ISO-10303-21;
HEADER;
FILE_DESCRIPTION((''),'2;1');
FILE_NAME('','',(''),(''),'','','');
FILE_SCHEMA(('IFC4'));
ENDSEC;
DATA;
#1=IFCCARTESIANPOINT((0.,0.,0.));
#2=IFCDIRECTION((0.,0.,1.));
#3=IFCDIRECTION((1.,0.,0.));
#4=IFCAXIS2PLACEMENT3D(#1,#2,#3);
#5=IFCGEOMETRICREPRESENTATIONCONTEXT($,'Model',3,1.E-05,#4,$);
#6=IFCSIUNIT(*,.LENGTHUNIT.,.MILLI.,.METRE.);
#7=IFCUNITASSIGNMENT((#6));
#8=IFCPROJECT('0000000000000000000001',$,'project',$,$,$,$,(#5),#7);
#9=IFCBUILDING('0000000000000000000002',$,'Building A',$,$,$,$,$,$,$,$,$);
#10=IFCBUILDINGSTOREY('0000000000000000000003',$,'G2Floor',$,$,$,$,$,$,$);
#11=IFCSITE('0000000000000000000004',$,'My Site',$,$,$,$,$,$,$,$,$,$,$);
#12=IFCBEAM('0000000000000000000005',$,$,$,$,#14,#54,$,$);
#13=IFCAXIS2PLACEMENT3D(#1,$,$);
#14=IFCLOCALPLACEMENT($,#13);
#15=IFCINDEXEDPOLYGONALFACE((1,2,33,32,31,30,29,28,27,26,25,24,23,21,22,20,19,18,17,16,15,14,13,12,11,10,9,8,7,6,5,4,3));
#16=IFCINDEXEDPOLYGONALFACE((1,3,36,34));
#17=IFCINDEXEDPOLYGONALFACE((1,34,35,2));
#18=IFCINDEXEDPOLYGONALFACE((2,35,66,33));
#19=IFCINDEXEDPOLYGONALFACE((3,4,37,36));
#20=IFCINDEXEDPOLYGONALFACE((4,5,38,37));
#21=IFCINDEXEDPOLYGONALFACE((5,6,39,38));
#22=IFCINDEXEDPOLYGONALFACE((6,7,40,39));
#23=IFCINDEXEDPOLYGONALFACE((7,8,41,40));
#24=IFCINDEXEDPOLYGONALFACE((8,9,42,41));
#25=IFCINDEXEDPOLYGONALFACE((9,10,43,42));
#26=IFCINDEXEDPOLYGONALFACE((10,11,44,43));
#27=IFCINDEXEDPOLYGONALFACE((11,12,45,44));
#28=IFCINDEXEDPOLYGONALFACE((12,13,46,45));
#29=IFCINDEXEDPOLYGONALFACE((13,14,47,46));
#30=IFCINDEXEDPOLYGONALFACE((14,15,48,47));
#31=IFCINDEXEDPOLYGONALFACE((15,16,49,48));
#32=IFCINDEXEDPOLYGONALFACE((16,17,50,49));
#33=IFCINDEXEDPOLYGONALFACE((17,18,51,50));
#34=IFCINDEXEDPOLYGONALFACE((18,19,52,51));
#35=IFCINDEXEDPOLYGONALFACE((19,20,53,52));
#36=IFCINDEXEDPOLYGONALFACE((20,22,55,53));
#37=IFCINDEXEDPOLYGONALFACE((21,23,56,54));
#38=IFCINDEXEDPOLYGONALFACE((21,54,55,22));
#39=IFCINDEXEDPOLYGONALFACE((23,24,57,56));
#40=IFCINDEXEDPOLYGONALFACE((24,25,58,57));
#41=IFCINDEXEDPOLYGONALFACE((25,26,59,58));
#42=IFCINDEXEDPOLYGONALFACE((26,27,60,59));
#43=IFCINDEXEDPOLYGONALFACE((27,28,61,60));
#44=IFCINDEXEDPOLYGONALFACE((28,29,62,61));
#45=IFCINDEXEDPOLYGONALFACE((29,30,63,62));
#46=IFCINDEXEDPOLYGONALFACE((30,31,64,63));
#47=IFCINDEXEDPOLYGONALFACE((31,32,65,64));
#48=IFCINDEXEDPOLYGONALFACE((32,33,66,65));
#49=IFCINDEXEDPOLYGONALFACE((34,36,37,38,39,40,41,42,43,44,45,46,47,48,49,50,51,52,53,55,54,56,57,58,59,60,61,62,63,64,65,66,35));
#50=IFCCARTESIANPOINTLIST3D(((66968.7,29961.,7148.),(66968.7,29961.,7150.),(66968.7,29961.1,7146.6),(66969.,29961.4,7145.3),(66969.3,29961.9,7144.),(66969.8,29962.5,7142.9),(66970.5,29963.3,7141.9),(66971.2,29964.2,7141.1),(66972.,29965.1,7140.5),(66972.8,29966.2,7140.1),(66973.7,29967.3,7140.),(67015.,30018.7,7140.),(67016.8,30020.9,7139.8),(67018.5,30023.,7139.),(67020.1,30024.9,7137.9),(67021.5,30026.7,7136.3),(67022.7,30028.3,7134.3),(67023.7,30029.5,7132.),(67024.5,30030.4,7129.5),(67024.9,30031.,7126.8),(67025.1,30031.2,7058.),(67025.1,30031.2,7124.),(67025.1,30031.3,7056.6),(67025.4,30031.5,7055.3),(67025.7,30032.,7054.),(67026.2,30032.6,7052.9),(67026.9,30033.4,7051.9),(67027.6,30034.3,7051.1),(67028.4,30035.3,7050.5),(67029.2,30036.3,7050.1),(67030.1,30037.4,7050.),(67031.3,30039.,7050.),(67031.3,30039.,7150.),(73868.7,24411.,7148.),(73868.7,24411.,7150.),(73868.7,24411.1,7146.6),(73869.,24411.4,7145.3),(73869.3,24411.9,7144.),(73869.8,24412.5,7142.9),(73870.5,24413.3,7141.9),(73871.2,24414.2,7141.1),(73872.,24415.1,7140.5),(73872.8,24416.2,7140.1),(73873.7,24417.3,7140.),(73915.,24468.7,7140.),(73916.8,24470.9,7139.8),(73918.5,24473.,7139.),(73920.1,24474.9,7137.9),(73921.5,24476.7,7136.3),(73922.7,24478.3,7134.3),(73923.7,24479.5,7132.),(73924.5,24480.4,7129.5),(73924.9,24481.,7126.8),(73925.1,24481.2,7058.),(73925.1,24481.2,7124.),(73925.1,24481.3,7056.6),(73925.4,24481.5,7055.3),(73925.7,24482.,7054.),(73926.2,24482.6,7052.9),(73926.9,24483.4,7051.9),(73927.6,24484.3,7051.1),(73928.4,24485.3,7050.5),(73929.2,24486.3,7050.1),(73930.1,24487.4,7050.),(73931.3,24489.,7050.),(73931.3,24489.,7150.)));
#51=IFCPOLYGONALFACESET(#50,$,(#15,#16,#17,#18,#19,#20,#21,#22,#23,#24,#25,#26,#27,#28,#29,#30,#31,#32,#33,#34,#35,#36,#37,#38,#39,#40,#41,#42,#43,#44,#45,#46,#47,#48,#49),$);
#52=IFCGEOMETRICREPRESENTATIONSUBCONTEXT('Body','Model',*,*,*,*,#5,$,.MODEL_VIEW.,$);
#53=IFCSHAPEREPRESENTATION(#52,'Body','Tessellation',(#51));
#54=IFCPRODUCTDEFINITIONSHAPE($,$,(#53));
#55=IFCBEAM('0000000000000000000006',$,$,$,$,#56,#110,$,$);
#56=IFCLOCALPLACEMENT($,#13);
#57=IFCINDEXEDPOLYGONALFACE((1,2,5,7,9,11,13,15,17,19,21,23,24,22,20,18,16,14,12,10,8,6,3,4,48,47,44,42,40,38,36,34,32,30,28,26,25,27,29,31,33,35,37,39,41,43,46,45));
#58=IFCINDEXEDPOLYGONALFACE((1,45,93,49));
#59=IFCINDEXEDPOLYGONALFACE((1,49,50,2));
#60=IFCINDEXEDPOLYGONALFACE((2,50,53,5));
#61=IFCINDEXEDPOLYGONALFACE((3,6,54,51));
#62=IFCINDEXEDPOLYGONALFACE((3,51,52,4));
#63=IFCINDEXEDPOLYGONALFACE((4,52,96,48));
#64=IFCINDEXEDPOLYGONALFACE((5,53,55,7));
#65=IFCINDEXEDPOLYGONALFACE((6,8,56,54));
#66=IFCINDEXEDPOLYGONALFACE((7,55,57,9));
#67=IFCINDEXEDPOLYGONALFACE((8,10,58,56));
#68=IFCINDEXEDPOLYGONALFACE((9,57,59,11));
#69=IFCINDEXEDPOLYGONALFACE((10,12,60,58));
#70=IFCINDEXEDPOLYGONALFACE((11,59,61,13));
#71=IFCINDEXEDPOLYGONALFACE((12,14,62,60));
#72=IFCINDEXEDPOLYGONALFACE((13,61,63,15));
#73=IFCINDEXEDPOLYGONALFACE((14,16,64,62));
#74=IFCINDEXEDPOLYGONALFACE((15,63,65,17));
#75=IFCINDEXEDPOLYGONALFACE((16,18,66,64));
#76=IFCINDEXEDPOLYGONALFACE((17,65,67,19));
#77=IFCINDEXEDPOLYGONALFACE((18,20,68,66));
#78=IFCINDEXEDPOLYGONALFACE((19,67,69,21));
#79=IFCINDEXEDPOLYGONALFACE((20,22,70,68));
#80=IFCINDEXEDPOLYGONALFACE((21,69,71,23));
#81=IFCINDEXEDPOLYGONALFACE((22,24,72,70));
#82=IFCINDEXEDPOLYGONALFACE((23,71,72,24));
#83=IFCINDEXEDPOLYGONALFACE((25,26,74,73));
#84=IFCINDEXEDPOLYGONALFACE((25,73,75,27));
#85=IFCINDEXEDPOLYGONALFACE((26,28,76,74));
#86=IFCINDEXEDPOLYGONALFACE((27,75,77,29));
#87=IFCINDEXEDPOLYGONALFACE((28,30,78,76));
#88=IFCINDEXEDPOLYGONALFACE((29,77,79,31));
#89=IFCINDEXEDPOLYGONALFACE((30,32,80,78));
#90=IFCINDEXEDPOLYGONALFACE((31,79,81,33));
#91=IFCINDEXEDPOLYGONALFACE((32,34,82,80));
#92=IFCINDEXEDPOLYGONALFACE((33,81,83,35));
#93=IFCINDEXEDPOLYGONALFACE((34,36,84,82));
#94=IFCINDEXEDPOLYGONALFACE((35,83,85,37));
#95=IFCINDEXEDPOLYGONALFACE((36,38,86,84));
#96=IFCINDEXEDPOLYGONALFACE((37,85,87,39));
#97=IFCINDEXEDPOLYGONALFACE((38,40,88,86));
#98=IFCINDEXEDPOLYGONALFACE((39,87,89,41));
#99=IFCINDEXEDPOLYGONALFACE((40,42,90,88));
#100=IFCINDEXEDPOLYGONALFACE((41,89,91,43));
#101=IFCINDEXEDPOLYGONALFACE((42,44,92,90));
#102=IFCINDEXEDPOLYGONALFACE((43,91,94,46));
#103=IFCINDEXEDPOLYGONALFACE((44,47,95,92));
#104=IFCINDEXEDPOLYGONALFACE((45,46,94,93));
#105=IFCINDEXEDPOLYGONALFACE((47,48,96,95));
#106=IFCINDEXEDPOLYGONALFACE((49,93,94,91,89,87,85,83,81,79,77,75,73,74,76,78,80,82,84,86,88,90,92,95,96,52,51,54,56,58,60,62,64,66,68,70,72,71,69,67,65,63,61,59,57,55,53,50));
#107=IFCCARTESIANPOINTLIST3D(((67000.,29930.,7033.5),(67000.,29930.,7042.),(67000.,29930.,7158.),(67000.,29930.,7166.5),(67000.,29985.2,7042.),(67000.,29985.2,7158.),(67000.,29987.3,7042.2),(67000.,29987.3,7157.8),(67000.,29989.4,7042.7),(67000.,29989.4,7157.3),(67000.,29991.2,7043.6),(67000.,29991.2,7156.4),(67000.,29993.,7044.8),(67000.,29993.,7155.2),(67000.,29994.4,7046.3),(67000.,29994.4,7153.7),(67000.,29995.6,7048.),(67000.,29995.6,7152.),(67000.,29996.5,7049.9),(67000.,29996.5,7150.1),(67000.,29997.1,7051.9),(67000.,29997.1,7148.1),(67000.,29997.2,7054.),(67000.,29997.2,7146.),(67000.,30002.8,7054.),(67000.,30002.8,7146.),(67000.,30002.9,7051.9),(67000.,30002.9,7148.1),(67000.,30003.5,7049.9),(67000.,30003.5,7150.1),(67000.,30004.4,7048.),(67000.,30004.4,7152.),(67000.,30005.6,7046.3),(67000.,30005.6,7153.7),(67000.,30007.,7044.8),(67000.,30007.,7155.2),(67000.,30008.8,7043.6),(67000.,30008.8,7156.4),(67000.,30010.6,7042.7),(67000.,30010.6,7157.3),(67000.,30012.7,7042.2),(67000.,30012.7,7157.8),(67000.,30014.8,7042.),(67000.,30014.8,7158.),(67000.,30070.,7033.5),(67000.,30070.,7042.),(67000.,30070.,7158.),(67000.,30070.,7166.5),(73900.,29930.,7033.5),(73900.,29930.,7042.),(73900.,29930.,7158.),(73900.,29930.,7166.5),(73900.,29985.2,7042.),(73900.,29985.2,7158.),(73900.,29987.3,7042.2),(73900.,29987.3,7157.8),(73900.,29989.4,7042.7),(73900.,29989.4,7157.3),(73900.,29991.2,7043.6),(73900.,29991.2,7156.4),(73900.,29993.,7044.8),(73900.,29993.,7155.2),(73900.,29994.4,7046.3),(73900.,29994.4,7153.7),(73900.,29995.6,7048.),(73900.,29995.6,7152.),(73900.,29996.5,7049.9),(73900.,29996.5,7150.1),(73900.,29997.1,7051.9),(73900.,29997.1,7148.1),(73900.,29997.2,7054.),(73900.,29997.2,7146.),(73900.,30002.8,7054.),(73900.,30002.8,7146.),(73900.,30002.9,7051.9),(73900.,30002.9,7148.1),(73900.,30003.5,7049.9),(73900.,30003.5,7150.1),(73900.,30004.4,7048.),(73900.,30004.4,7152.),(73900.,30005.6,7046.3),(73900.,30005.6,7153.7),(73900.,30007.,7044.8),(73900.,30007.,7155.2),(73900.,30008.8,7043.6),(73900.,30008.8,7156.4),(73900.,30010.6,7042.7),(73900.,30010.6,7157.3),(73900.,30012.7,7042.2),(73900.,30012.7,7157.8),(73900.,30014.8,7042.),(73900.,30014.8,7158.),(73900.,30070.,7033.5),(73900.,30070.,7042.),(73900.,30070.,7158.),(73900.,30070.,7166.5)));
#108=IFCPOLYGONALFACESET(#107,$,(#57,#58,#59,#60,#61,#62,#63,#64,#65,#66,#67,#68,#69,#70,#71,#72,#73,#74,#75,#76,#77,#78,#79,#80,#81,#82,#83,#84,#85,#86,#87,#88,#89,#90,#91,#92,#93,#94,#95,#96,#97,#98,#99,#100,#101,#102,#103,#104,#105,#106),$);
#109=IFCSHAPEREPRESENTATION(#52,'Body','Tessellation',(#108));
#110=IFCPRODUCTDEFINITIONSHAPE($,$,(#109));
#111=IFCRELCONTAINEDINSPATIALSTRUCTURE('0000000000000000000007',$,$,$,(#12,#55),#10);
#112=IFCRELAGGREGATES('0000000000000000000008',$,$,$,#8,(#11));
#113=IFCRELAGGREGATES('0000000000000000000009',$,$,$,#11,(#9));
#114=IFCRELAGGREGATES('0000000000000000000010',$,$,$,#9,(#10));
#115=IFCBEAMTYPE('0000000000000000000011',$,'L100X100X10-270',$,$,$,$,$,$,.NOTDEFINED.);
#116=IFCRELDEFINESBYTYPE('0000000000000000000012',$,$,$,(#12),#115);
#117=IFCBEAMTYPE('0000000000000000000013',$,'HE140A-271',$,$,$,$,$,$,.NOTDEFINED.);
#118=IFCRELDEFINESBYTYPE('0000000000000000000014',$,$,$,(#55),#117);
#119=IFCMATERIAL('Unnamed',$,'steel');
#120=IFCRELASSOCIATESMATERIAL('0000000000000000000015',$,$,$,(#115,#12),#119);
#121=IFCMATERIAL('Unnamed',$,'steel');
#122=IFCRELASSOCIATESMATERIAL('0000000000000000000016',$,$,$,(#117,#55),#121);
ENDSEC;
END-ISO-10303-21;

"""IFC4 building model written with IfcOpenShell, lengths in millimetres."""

from ifc_helpers import new_model, si_unit, frame, origin_with_axes, place, context, subcontext, project, spatial, polyline, outline, extrude, material, material_profile, profile_set, profile_usage, type_object, element, save


model = new_model("IFC4")

# Units and contexts
model_context = context("Model", 3, precision=1e-05, world=origin_with_axes())
body_context = subcontext(model_context, "Body", "Model", "MODEL_VIEW")
ifc_project = project(units=[si_unit("LENGTHUNIT", "METRE", prefix="MILLI")], contexts=[model_context])

# Site, building, storey
site = spatial("IfcSite", under=ifc_project, Name="My Site")
building = spatial("IfcBuilding", under=site, Name="Building A")
storey = spatial("IfcBuildingStorey", under=building, Name="G2Floor")

# Beams
ifc_material_1 = material(Name="Unnamed", Category="steel")
ifc_material_profile_1 = material_profile(ifc_material_1, outline(polyline([(-50.0, -50.0), (50.0, -50.0), (50.0, -50.0), (50.0, -48.0), (50.0, -48.0), (49.9, -46.6), (49.9, -46.6), (49.5, -45.3), (49.5, -45.3), (48.9, -44.0), (48.9, -44.0), (48.1, -42.9), (48.1, -42.9), (47.1, -41.9), (47.1, -41.9), (46.0, -41.1), (46.0, -41.1), (44.7, -40.5), (44.7, -40.5), (43.4, -40.1), (43.4, -40.1), (42.0, -40.0), (42.0, -40.0), (-24.0, -40.0), (-24.0, -40.0), (-26.8, -39.8), (-26.8, -39.8), (-29.5, -39.0), (-29.5, -39.0), (-32.0, -37.9), (-32.0, -37.9), (-34.3, -36.3), (-34.3, -36.3), (-36.3, -34.3), (-36.3, -34.3), (-37.9, -32.0), (-37.9, -32.0), (-39.0, -29.5), (-39.0, -29.5), (-39.8, -26.8), (-39.8, -26.8), (-40.0, -24.0), (-40.0, -24.0), (-40.0, 42.0), (-40.0, 42.0), (-40.1, 43.4), (-40.1, 43.4), (-40.5, 44.7), (-40.5, 44.7), (-41.1, 46.0), (-41.1, 46.0), (-41.9, 47.1), (-41.9, 47.1), (-42.9, 48.1), (-42.9, 48.1), (-44.0, 48.9), (-44.0, 48.9), (-45.3, 49.5), (-45.3, 49.5), (-46.6, 49.9), (-46.6, 49.9), (-48.0, 50.0), (-48.0, 50.0), (-50.0, 50.0), (-50.0, 50.0), (-50.0, -50.0)])))
ifc_profile_set_1 = profile_set([ifc_material_profile_1], Name="L100X100X10-270")
ifc_profile_usage_1 = profile_usage(ifc_profile_set_1)
beam_type_1 = type_object("IfcBeamType", Name="L100X100X10-270", PredefinedType="NOTDEFINED", material=ifc_profile_set_1)
beam_1_placement = place(None, frame((67000.0, 30000.0, 7100.0), z_axis=(0.779213, -0.626759, 0.0), x_axis=(-0.626759, -0.779213, 0.0)))
element("IfcBeam", 1, at=beam_1_placement, inside=storey, type_object=beam_type_1, material=ifc_profile_usage_1, context=body_context, shape_type="SweptSolid", body=[
    extrude(outline(polyline([(-50.0, -50.0), (50.0, -50.0), (50.0, -50.0), (50.0, -48.0), (50.0, -48.0), (49.9, -46.6), (49.9, -46.6), (49.5, -45.3), (49.5, -45.3), (48.9, -44.0), (48.9, -44.0), (48.1, -42.9), (48.1, -42.9), (47.1, -41.9), (47.1, -41.9), (46.0, -41.1), (46.0, -41.1), (44.7, -40.5), (44.7, -40.5), (43.4, -40.1), (43.4, -40.1), (42.0, -40.0), (42.0, -40.0), (-24.0, -40.0), (-24.0, -40.0), (-26.8, -39.8), (-26.8, -39.8), (-29.5, -39.0), (-29.5, -39.0), (-32.0, -37.9), (-32.0, -37.9), (-34.3, -36.3), (-34.3, -36.3), (-36.3, -34.3), (-36.3, -34.3), (-37.9, -32.0), (-37.9, -32.0), (-39.0, -29.5), (-39.0, -29.5), (-39.8, -26.8), (-39.8, -26.8), (-40.0, -24.0), (-40.0, -24.0), (-40.0, 42.0), (-40.0, 42.0), (-40.1, 43.4), (-40.1, 43.4), (-40.5, 44.7), (-40.5, 44.7), (-41.1, 46.0), (-41.1, 46.0), (-41.9, 47.1), (-41.9, 47.1), (-42.9, 48.1), (-42.9, 48.1), (-44.0, 48.9), (-44.0, 48.9), (-45.3, 49.5), (-45.3, 49.5), (-46.6, 49.9), (-46.6, 49.9), (-48.0, 50.0), (-48.0, 50.0), (-50.0, 50.0), (-50.0, 50.0), (-50.0, -50.0)])), origin_with_axes(), (0.0, 0.0, 1.0), 8855.1),
])
ifc_material_2 = material(Name="Unnamed", Category="steel")
ifc_material_profile_2 = material_profile(ifc_material_2, outline(polyline([(70.0, -66.5), (70.0, -58.0), (70.0, -58.0), (14.8, -58.0), (14.8, -58.0), (12.7, -57.8), (12.7, -57.8), (10.6, -57.3), (10.6, -57.3), (8.8, -56.4), (8.8, -56.4), (7.0, -55.2), (7.0, -55.2), (5.6, -53.7), (5.6, -53.7), (4.4, -52.0), (4.4, -52.0), (3.5, -50.1), (3.5, -50.1), (2.9, -48.1), (2.9, -48.1), (2.8, -46.0), (2.8, -46.0), (2.8, 46.0), (2.8, 46.0), (2.9, 48.1), (2.9, 48.1), (3.5, 50.1), (3.5, 50.1), (4.4, 52.0), (4.4, 52.0), (5.6, 53.7), (5.6, 53.7), (7.0, 55.2), (7.0, 55.2), (8.8, 56.4), (8.8, 56.4), (10.6, 57.3), (10.6, 57.3), (12.7, 57.8), (12.7, 57.8), (14.8, 58.0), (14.8, 58.0), (70.0, 58.0), (70.0, 58.0), (70.0, 66.5), (70.0, 66.5), (-70.0, 66.5), (-70.0, 66.5), (-70.0, 58.0), (-70.0, 58.0), (-14.8, 58.0), (-14.8, 58.0), (-12.7, 57.8), (-12.7, 57.8), (-10.6, 57.3), (-10.6, 57.3), (-8.8, 56.4), (-8.8, 56.4), (-7.0, 55.2), (-7.0, 55.2), (-5.6, 53.7), (-5.6, 53.7), (-4.4, 52.0), (-4.4, 52.0), (-3.5, 50.1), (-3.5, 50.1), (-2.9, 48.1), (-2.9, 48.1), (-2.8, 46.0), (-2.8, 46.0), (-2.8, -46.0), (-2.8, -46.0), (-2.9, -48.1), (-2.9, -48.1), (-3.5, -50.1), (-3.5, -50.1), (-4.4, -52.0), (-4.4, -52.0), (-5.6, -53.7), (-5.6, -53.7), (-7.0, -55.2), (-7.0, -55.2), (-8.8, -56.4), (-8.8, -56.4), (-10.6, -57.3), (-10.6, -57.3), (-12.7, -57.8), (-12.7, -57.8), (-14.8, -58.0), (-14.8, -58.0), (-70.0, -58.0), (-70.0, -58.0), (-70.0, -66.5), (-70.0, -66.5), (70.0, -66.5)])))
ifc_profile_set_2 = profile_set([ifc_material_profile_2], Name="HE140A-271")
ifc_profile_usage_2 = profile_usage(ifc_profile_set_2)
beam_type_2 = type_object("IfcBeamType", Name="HE140A-271", PredefinedType="NOTDEFINED", material=ifc_profile_set_2)
beam_2_placement = place(None, frame((67000.0, 30000.0, 7100.0), z_axis=(1.0, 0.0, 0.0), x_axis=(0.0, -1.0, 0.0)))
element("IfcBeam", 2, at=beam_2_placement, inside=storey, type_object=beam_type_2, material=ifc_profile_usage_2, context=body_context, shape_type="SweptSolid", body=[
    extrude(outline(polyline([(70.0, -66.5), (70.0, -58.0), (70.0, -58.0), (14.8, -58.0), (14.8, -58.0), (12.7, -57.8), (12.7, -57.8), (10.6, -57.3), (10.6, -57.3), (8.8, -56.4), (8.8, -56.4), (7.0, -55.2), (7.0, -55.2), (5.6, -53.7), (5.6, -53.7), (4.4, -52.0), (4.4, -52.0), (3.5, -50.1), (3.5, -50.1), (2.9, -48.1), (2.9, -48.1), (2.8, -46.0), (2.8, -46.0), (2.8, 46.0), (2.8, 46.0), (2.9, 48.1), (2.9, 48.1), (3.5, 50.1), (3.5, 50.1), (4.4, 52.0), (4.4, 52.0), (5.6, 53.7), (5.6, 53.7), (7.0, 55.2), (7.0, 55.2), (8.8, 56.4), (8.8, 56.4), (10.6, 57.3), (10.6, 57.3), (12.7, 57.8), (12.7, 57.8), (14.8, 58.0), (14.8, 58.0), (70.0, 58.0), (70.0, 58.0), (70.0, 66.5), (70.0, 66.5), (-70.0, 66.5), (-70.0, 66.5), (-70.0, 58.0), (-70.0, 58.0), (-14.8, 58.0), (-14.8, 58.0), (-12.7, 57.8), (-12.7, 57.8), (-10.6, 57.3), (-10.6, 57.3), (-8.8, 56.4), (-8.8, 56.4), (-7.0, 55.2), (-7.0, 55.2), (-5.6, 53.7), (-5.6, 53.7), (-4.4, 52.0), (-4.4, 52.0), (-3.5, 50.1), (-3.5, 50.1), (-2.9, 48.1), (-2.9, 48.1), (-2.8, 46.0), (-2.8, 46.0), (-2.8, -46.0), (-2.8, -46.0), (-2.9, -48.1), (-2.9, -48.1), (-3.5, -50.1), (-3.5, -50.1), (-4.4, -52.0), (-4.4, -52.0), (-5.6, -53.7), (-5.6, -53.7), (-7.0, -55.2), (-7.0, -55.2), (-8.8, -56.4), (-8.8, -56.4), (-10.6, -57.3), (-10.6, -57.3), (-12.7, -57.8), (-12.7, -57.8), (-14.8, -58.0), (-14.8, -58.0), (-70.0, -58.0), (-70.0, -58.0), (-70.0, -66.5), (-70.0, -66.5), (70.0, -66.5)])), origin_with_axes(), (0.0, 0.0, 1.0), 6900.0),
])

save(model, "model.ifc")
